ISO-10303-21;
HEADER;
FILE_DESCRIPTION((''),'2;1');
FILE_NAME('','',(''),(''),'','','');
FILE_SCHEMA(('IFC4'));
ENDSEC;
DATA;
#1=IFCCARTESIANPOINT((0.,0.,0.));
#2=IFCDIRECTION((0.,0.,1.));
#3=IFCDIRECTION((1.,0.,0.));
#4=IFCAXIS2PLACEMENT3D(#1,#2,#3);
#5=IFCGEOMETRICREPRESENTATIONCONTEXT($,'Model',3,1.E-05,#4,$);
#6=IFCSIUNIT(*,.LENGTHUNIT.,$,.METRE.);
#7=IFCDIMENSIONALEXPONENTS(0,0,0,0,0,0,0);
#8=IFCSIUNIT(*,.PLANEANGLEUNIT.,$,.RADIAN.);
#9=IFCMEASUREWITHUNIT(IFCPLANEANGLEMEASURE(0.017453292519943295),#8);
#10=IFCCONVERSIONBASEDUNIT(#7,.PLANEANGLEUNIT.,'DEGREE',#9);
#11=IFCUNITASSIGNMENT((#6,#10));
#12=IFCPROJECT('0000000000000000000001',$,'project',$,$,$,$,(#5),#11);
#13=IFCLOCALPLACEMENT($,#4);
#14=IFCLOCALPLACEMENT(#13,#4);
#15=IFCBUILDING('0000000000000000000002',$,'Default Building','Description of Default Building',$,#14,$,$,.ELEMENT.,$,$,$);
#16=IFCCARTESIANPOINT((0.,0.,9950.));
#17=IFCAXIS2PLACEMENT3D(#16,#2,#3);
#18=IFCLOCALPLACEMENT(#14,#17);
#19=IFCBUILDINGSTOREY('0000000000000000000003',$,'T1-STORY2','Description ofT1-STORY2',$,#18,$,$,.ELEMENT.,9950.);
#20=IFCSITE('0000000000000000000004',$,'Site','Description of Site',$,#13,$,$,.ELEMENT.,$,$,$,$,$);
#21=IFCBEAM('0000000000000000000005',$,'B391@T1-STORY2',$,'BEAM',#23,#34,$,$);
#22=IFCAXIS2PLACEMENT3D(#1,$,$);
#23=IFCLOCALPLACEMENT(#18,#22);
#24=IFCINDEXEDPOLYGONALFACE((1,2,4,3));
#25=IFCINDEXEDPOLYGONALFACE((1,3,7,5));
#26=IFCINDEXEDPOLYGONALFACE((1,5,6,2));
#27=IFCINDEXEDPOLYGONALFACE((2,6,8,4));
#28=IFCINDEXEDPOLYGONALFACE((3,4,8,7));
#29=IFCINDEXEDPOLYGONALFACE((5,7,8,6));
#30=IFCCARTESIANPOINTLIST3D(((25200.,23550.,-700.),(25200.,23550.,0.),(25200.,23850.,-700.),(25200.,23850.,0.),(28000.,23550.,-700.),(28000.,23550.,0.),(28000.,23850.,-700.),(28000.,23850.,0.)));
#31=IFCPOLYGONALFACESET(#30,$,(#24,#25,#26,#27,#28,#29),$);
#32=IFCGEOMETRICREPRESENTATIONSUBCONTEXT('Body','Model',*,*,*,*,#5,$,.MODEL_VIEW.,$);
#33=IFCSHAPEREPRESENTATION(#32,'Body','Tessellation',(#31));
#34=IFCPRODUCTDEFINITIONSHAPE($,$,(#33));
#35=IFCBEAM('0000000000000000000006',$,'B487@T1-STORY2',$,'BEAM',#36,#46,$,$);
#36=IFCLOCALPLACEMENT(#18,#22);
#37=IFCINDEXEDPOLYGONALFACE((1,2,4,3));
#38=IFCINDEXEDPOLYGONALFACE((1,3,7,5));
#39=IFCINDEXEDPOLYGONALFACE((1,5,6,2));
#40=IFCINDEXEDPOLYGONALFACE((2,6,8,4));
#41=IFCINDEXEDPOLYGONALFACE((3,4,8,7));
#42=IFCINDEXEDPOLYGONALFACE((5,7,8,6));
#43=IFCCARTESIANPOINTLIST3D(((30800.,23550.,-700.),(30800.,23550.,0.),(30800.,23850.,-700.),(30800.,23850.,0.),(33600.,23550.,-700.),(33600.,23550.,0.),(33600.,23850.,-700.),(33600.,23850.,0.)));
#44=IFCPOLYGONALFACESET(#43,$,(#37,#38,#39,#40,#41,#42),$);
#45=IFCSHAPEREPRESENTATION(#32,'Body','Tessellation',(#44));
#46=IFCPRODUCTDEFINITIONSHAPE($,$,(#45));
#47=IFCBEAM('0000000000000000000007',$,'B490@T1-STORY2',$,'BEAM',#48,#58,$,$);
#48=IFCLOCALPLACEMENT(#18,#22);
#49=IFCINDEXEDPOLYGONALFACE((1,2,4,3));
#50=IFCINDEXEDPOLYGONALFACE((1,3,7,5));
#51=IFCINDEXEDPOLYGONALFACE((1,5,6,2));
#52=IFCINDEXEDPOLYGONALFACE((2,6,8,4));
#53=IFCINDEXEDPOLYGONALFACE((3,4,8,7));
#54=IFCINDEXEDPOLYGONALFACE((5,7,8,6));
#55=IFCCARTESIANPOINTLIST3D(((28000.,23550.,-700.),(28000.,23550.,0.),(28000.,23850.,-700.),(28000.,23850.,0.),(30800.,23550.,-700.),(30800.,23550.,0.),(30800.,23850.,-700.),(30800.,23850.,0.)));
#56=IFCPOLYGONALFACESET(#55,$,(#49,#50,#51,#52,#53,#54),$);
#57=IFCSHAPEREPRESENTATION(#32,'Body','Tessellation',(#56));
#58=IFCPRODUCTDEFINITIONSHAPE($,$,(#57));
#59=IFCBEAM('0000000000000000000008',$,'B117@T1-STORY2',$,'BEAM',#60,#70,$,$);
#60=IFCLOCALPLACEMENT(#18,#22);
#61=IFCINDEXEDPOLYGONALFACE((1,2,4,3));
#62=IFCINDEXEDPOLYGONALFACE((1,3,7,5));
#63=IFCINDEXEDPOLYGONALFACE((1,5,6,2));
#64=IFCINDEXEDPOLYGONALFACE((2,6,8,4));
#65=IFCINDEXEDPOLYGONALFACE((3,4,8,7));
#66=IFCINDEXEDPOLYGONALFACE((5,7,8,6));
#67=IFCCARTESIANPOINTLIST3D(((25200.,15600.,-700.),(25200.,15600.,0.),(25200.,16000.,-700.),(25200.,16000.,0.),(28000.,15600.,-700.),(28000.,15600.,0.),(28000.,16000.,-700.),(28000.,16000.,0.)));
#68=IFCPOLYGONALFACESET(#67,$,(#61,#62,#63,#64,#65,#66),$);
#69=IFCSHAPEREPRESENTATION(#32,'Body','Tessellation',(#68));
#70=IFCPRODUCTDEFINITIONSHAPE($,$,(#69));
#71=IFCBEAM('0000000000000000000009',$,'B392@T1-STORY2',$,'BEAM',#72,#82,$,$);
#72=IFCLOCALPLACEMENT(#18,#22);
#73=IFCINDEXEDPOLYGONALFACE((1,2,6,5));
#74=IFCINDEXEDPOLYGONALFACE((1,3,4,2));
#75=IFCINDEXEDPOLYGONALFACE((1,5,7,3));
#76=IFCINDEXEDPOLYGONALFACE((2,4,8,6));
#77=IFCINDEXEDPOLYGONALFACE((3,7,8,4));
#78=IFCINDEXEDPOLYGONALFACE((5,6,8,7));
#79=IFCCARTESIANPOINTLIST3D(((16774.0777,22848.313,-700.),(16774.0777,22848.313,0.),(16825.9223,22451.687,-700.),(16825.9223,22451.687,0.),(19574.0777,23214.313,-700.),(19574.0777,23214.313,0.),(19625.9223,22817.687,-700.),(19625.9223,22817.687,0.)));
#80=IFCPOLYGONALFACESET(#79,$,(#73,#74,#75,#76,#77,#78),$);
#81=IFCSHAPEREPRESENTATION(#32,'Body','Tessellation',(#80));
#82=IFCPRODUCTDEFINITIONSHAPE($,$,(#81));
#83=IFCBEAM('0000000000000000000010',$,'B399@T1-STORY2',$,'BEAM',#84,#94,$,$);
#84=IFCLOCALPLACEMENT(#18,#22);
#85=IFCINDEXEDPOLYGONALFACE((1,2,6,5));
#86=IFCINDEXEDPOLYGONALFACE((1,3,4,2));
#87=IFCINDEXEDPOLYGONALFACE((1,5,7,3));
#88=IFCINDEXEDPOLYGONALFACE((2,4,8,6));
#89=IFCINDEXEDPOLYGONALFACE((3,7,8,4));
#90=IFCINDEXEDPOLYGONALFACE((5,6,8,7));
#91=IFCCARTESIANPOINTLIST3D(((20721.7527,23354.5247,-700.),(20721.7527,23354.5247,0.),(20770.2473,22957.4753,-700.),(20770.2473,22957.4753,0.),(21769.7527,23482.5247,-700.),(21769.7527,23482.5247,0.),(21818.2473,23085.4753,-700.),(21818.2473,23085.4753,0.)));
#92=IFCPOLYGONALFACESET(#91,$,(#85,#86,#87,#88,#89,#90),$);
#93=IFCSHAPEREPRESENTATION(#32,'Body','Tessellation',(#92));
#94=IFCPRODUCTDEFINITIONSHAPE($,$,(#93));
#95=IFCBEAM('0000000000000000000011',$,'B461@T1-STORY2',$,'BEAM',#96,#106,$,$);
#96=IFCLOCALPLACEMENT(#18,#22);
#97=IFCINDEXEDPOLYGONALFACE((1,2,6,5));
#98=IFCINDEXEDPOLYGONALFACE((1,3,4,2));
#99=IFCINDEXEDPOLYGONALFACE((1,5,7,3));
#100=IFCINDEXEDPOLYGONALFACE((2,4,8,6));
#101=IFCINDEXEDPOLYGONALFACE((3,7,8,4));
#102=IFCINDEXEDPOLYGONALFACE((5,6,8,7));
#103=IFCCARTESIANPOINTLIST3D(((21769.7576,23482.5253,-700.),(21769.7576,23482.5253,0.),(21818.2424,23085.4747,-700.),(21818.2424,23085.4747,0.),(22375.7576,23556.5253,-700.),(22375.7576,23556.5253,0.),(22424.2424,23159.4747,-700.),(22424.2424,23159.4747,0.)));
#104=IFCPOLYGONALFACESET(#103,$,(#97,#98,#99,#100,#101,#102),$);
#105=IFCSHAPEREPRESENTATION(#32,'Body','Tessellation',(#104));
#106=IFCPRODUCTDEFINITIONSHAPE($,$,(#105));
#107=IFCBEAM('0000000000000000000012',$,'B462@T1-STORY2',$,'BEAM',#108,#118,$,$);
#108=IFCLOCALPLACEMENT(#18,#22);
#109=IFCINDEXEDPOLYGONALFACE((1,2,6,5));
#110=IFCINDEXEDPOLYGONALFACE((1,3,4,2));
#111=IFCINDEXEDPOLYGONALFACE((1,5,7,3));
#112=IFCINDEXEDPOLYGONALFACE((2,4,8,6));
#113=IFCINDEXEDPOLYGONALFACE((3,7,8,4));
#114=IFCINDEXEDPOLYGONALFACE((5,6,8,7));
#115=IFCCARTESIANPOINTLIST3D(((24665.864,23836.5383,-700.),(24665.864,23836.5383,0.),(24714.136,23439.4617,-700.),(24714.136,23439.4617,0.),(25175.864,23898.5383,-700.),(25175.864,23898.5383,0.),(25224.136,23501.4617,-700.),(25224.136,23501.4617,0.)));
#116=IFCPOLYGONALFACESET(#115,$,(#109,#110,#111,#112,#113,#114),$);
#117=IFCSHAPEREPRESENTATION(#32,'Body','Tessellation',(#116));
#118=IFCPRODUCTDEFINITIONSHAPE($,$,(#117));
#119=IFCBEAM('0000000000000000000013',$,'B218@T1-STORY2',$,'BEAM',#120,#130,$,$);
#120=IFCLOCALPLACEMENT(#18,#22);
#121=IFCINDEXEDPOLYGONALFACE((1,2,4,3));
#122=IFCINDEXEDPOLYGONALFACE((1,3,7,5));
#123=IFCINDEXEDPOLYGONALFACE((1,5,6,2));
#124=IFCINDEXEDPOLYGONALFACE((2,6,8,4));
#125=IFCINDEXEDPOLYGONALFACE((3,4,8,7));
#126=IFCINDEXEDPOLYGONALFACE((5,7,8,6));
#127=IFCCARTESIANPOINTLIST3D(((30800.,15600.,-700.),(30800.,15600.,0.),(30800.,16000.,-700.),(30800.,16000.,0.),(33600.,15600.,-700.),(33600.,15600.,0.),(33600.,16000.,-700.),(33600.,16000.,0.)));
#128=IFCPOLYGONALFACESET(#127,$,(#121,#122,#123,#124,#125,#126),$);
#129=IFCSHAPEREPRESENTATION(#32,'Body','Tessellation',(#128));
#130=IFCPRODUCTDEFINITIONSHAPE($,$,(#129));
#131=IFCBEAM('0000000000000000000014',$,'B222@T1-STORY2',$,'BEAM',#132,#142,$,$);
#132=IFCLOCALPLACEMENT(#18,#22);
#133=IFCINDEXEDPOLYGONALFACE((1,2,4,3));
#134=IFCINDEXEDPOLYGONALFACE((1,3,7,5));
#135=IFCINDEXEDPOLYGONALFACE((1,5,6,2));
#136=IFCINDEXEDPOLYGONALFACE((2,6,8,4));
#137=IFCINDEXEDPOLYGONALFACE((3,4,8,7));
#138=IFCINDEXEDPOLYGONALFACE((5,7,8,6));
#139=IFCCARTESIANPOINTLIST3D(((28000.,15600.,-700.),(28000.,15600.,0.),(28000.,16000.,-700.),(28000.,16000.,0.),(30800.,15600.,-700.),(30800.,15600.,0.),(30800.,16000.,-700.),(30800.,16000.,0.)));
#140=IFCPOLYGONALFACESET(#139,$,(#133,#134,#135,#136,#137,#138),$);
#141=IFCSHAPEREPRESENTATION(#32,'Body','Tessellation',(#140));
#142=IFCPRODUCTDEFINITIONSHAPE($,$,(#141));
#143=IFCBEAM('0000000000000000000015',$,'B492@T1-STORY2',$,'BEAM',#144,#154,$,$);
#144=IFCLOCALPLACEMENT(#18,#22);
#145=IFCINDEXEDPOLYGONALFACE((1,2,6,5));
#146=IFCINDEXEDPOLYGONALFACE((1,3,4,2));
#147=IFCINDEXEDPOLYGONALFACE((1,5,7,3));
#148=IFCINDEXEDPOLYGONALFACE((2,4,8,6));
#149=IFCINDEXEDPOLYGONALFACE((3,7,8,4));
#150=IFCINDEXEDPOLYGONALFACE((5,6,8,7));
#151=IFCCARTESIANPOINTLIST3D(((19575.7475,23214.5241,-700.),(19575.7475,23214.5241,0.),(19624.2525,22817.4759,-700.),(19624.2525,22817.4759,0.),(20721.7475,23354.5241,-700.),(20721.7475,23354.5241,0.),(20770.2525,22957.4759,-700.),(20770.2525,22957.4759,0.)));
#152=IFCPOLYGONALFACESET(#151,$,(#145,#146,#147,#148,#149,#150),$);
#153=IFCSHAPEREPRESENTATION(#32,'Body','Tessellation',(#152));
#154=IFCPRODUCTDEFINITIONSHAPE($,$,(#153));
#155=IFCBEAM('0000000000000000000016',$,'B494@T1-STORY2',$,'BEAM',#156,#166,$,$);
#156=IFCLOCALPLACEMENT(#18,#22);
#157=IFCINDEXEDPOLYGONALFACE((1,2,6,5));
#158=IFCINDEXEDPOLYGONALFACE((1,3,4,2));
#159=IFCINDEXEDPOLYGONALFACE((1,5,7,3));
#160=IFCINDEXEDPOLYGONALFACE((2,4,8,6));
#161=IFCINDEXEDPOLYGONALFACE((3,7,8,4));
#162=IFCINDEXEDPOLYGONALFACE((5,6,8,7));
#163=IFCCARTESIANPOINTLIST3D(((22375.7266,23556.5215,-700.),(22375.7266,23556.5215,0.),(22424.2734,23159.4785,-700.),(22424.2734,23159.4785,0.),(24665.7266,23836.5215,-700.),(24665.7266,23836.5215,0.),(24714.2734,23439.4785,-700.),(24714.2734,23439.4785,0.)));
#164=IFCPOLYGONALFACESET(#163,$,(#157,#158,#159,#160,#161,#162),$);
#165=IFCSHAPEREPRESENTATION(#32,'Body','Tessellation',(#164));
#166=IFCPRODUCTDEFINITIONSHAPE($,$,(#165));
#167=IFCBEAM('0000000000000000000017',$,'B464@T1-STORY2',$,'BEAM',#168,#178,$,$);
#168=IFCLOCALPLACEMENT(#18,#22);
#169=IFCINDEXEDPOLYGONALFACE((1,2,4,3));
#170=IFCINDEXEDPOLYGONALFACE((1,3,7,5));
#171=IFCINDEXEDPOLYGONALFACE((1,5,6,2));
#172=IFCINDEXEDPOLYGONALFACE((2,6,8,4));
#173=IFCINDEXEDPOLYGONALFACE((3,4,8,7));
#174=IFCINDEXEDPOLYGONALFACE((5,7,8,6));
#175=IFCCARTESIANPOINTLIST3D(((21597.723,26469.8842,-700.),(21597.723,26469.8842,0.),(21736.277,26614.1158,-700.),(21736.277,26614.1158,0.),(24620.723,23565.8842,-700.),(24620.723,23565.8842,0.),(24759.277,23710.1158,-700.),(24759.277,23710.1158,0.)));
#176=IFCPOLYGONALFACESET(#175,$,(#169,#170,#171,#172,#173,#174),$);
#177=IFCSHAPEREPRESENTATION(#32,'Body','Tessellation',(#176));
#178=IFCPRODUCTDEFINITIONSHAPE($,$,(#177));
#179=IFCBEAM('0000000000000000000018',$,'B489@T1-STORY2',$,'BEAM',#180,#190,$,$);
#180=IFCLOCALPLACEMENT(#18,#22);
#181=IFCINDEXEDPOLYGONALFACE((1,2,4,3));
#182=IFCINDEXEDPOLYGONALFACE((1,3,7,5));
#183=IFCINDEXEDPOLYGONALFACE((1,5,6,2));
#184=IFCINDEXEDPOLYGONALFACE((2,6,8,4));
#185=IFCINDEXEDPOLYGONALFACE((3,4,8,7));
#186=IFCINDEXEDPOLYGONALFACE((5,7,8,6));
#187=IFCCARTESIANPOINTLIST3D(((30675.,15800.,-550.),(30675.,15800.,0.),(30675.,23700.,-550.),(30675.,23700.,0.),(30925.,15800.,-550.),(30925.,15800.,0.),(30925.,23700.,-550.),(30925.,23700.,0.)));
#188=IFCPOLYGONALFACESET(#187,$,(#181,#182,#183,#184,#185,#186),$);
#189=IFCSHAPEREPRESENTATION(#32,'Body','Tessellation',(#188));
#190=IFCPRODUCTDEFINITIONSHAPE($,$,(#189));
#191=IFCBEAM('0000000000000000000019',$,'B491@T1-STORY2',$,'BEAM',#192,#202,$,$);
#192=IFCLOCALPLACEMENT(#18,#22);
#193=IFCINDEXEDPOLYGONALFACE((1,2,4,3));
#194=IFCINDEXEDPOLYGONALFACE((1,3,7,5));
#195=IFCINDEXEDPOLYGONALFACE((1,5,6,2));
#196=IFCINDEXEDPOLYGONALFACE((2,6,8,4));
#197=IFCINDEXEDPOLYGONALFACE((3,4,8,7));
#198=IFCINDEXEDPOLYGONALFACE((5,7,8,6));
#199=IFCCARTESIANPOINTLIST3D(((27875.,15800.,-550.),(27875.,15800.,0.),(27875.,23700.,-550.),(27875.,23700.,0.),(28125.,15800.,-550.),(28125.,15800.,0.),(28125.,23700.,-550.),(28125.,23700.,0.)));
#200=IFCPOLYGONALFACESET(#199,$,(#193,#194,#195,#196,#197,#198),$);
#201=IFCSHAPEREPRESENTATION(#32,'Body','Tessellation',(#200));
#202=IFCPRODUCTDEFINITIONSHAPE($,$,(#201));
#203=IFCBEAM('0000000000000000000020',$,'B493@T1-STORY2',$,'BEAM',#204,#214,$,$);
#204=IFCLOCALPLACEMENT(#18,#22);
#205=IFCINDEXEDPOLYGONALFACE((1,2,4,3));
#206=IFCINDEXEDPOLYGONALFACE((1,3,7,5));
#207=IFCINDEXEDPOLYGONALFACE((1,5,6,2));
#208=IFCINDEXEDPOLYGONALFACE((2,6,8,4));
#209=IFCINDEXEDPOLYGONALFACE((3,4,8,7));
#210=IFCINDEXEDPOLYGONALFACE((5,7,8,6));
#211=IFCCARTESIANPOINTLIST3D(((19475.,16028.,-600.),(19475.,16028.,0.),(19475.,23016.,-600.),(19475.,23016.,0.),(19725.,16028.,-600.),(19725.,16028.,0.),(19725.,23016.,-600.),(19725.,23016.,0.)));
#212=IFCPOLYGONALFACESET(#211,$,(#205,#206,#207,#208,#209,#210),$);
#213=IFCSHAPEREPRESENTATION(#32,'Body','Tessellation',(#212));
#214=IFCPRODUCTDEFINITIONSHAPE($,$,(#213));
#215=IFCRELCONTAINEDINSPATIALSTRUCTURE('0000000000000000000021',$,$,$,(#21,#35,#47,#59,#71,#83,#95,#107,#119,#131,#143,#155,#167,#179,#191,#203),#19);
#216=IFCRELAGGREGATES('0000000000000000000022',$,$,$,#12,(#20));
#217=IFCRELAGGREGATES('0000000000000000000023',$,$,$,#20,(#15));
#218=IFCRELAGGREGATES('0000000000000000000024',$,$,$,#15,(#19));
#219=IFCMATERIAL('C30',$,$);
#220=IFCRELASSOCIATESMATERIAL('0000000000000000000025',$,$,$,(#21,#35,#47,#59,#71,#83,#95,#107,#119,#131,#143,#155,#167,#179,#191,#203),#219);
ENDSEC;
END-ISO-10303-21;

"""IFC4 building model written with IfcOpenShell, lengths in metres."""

from ifc_helpers import new_model, entity, si_unit, converted_unit, frame, origin_with_axes, place, context, subcontext, project, spatial, rectangle, extrude, material, element, save


model = new_model("IFC4")

# Units and contexts
model_context = context("Model", 3, precision=1e-05, world=origin_with_axes())
body_context = subcontext(model_context, "Body", "Model", "MODEL_VIEW")
ifc_project = project(units=[si_unit("LENGTHUNIT", "METRE"), converted_unit("PLANEANGLEUNIT", "DEGREE", entity("IfcPlaneAngleMeasure", 0.017453292519943295), si_unit("PLANEANGLEUNIT", "RADIAN"), dimensions=[0, 0, 0, 0, 0, 0, 0])], contexts=[model_context])

# Site, building, storey
site_placement = place(None, origin_with_axes())
site = spatial("IfcSite", under=ifc_project, at=site_placement, Name="Site", Description="Description of Site", CompositionType="ELEMENT")
building_placement = place(site_placement, origin_with_axes())
building = spatial("IfcBuilding", under=site, at=building_placement, Name="Default Building", Description="Description of Default Building", CompositionType="ELEMENT")
storey_placement = place(building_placement, frame((0.0, 0.0, 9950.0), z_axis=(0.0, 0.0, 1.0), x_axis=(1.0, 0.0, 0.0)))
storey = spatial("IfcBuildingStorey", under=building, at=storey_placement, Name="T1-STORY2", Description="Description ofT1-STORY2", CompositionType="ELEMENT", Elevation=9950.0)

# Beams
ifc_material_1 = material(Name="C30")
for number, where, z_axis, x_axis, name in (
    (1, (25200.0, 23700.0, -350.0), (1.0, 0.0, 0.0), (0.0, 1.0, 0.0), "B391@T1-STORY2"),
    (2, (30800.0, 23700.0, -350.0), (1.0, 0.0, 0.0), (0.0, 1.0, 0.0), "B487@T1-STORY2"),
    (3, (28000.0, 23700.0, -350.0), (1.0, 0.0, 0.0), (0.0, 1.0, 0.0), "B490@T1-STORY2"),
):
    element("IfcBeam", number, at=place(storey_placement, frame(where, z_axis=z_axis, x_axis=x_axis)), inside=storey, material=ifc_material_1, Name=name, ObjectType="BEAM", context=body_context, shape_type="SweptSolid", body=[
        extrude(rectangle(XDim=300.0, YDim=700.0), origin_with_axes(), (0.0, 0.0, 1.0), 2800.0),
    ])
beam_1_placement = place(storey_placement, frame((25200.0, 15800.0, -350.0), z_axis=(1.0, 0.0, 0.0), x_axis=(0.0, 1.0, 0.0)))
element("IfcBeam", 4, at=beam_1_placement, inside=storey, material=ifc_material_1, Name="B117@T1-STORY2", ObjectType="BEAM", context=body_context, shape_type="SweptSolid", body=[
    extrude(rectangle(XDim=400.0, YDim=700.0), origin_with_axes(), (0.0, 0.0, 1.0), 2800.0),
])
beam_2_placement = place(storey_placement, frame((16800.0, 22650.0, -350.0), z_axis=(0.991565, 0.129612, 0.0), x_axis=(-0.129612, 0.991565, 0.0)))
element("IfcBeam", 5, at=beam_2_placement, inside=storey, material=ifc_material_1, Name="B392@T1-STORY2", ObjectType="BEAM", context=body_context, shape_type="SweptSolid", body=[
    extrude(rectangle(XDim=400.0, YDim=700.0), origin_with_axes(), (0.0, 0.0, 1.0), 2823.8194),
])
beam_3_placement = place(storey_placement, frame((20746.0, 23156.0, -350.0), z_axis=(0.992624, 0.121236, 0.0), x_axis=(-0.121236, 0.992624, 0.0)))
element("IfcBeam", 6, at=beam_3_placement, inside=storey, material=ifc_material_1, Name="B399@T1-STORY2", ObjectType="BEAM", context=body_context, shape_type="SweptSolid", body=[
    extrude(rectangle(XDim=400.0, YDim=700.0), origin_with_axes(), (0.0, 0.0, 1.0), 1055.7879),
])
beam_4_placement = place(storey_placement, frame((21794.0, 23284.0, -350.0), z_axis=(0.992627, 0.121212, 0.0), x_axis=(-0.121212, 0.992627, 0.0)))
element("IfcBeam", 7, at=beam_4_placement, inside=storey, material=ifc_material_1, Name="B461@T1-STORY2", ObjectType="BEAM", context=body_context, shape_type="SweptSolid", body=[
    extrude(rectangle(XDim=400.0, YDim=700.0), origin_with_axes(), (0.0, 0.0, 1.0), 610.5014),
])
beam_5_placement = place(storey_placement, frame((24690.0, 23638.0, -350.0), z_axis=(0.992691, 0.12068, 0.0), x_axis=(-0.12068, 0.992691, 0.0)))
element("IfcBeam", 8, at=beam_5_placement, inside=storey, material=ifc_material_1, Name="B462@T1-STORY2", ObjectType="BEAM", context=body_context, shape_type="SweptSolid", body=[
    extrude(rectangle(XDim=400.0, YDim=700.0), origin_with_axes(), (0.0, 0.0, 1.0), 513.7548),
])
for number, where, z_axis, x_axis, name in (
    (9, (30800.0, 15800.0, -350.0), (1.0, 0.0, 0.0), (0.0, 1.0, 0.0), "B218@T1-STORY2"),
    (10, (28000.0, 15800.0, -350.0), (1.0, 0.0, 0.0), (0.0, 1.0, 0.0), "B222@T1-STORY2"),
):
    element("IfcBeam", number, at=place(storey_placement, frame(where, z_axis=z_axis, x_axis=x_axis)), inside=storey, material=ifc_material_1, Name=name, ObjectType="BEAM", context=body_context, shape_type="SweptSolid", body=[
        extrude(rectangle(XDim=400.0, YDim=700.0), origin_with_axes(), (0.0, 0.0, 1.0), 2800.0),
    ])
beam_6_placement = place(storey_placement, frame((19600.0, 23016.0, -350.0), z_axis=(0.99262, 0.121263, 0.0), x_axis=(-0.121263, 0.99262, 0.0)))
element("IfcBeam", 11, at=beam_6_placement, inside=storey, material=ifc_material_1, Name="B492@T1-STORY2", ObjectType="BEAM", context=body_context, shape_type="SweptSolid", body=[
    extrude(rectangle(XDim=400.0, YDim=700.0), origin_with_axes(), (0.0, 0.0, 1.0), 1154.5198),
])
beam_7_placement = place(storey_placement, frame((22400.0, 23358.0, -350.0), z_axis=(0.992608, 0.121367, 0.0), x_axis=(-0.121367, 0.992608, 0.0)))
element("IfcBeam", 12, at=beam_7_placement, inside=storey, material=ifc_material_1, Name="B494@T1-STORY2", ObjectType="BEAM", context=body_context, shape_type="SweptSolid", body=[
    extrude(rectangle(XDim=400.0, YDim=700.0), origin_with_axes(), (0.0, 0.0, 1.0), 2307.0544),
])
beam_8_placement = place(storey_placement, frame((21667.0, 26542.0, -350.0), z_axis=(0.721158, -0.69277, 0.0), x_axis=(0.69277, 0.721158, 0.0)))
element("IfcBeam", 13, at=beam_8_placement, inside=storey, material=ifc_material_1, Name="B464@T1-STORY2", ObjectType="BEAM", context=body_context, shape_type="SweptSolid", body=[
    extrude(rectangle(XDim=200.0, YDim=700.0), origin_with_axes(), (0.0, 0.0, 1.0), 4191.8665),
])
for number, where, z_axis, x_axis, name in (
    (14, (30800.0, 15800.0, -275.0), (0.0, 1.0, 0.0), (-1.0, 0.0, 0.0), "B489@T1-STORY2"),
    (15, (28000.0, 15800.0, -275.0), (0.0, 1.0, 0.0), (-1.0, 0.0, 0.0), "B491@T1-STORY2"),
):
    element("IfcBeam", number, at=place(storey_placement, frame(where, z_axis=z_axis, x_axis=x_axis)), inside=storey, material=ifc_material_1, Name=name, ObjectType="BEAM", context=body_context, shape_type="SweptSolid", body=[
        extrude(rectangle(XDim=250.0, YDim=550.0), origin_with_axes(), (0.0, 0.0, 1.0), 7900.0),
    ])
beam_9_placement = place(storey_placement, frame((19600.0, 16028.0, -300.0), z_axis=(0.0, 1.0, 0.0), x_axis=(-1.0, 0.0, 0.0)))
element("IfcBeam", 16, at=beam_9_placement, inside=storey, material=ifc_material_1, Name="B493@T1-STORY2", ObjectType="BEAM", context=body_context, shape_type="SweptSolid", body=[
    extrude(rectangle(XDim=250.0, YDim=600.0), origin_with_axes(), (0.0, 0.0, 1.0), 6988.0),
])

save(model, "model.ifc")
